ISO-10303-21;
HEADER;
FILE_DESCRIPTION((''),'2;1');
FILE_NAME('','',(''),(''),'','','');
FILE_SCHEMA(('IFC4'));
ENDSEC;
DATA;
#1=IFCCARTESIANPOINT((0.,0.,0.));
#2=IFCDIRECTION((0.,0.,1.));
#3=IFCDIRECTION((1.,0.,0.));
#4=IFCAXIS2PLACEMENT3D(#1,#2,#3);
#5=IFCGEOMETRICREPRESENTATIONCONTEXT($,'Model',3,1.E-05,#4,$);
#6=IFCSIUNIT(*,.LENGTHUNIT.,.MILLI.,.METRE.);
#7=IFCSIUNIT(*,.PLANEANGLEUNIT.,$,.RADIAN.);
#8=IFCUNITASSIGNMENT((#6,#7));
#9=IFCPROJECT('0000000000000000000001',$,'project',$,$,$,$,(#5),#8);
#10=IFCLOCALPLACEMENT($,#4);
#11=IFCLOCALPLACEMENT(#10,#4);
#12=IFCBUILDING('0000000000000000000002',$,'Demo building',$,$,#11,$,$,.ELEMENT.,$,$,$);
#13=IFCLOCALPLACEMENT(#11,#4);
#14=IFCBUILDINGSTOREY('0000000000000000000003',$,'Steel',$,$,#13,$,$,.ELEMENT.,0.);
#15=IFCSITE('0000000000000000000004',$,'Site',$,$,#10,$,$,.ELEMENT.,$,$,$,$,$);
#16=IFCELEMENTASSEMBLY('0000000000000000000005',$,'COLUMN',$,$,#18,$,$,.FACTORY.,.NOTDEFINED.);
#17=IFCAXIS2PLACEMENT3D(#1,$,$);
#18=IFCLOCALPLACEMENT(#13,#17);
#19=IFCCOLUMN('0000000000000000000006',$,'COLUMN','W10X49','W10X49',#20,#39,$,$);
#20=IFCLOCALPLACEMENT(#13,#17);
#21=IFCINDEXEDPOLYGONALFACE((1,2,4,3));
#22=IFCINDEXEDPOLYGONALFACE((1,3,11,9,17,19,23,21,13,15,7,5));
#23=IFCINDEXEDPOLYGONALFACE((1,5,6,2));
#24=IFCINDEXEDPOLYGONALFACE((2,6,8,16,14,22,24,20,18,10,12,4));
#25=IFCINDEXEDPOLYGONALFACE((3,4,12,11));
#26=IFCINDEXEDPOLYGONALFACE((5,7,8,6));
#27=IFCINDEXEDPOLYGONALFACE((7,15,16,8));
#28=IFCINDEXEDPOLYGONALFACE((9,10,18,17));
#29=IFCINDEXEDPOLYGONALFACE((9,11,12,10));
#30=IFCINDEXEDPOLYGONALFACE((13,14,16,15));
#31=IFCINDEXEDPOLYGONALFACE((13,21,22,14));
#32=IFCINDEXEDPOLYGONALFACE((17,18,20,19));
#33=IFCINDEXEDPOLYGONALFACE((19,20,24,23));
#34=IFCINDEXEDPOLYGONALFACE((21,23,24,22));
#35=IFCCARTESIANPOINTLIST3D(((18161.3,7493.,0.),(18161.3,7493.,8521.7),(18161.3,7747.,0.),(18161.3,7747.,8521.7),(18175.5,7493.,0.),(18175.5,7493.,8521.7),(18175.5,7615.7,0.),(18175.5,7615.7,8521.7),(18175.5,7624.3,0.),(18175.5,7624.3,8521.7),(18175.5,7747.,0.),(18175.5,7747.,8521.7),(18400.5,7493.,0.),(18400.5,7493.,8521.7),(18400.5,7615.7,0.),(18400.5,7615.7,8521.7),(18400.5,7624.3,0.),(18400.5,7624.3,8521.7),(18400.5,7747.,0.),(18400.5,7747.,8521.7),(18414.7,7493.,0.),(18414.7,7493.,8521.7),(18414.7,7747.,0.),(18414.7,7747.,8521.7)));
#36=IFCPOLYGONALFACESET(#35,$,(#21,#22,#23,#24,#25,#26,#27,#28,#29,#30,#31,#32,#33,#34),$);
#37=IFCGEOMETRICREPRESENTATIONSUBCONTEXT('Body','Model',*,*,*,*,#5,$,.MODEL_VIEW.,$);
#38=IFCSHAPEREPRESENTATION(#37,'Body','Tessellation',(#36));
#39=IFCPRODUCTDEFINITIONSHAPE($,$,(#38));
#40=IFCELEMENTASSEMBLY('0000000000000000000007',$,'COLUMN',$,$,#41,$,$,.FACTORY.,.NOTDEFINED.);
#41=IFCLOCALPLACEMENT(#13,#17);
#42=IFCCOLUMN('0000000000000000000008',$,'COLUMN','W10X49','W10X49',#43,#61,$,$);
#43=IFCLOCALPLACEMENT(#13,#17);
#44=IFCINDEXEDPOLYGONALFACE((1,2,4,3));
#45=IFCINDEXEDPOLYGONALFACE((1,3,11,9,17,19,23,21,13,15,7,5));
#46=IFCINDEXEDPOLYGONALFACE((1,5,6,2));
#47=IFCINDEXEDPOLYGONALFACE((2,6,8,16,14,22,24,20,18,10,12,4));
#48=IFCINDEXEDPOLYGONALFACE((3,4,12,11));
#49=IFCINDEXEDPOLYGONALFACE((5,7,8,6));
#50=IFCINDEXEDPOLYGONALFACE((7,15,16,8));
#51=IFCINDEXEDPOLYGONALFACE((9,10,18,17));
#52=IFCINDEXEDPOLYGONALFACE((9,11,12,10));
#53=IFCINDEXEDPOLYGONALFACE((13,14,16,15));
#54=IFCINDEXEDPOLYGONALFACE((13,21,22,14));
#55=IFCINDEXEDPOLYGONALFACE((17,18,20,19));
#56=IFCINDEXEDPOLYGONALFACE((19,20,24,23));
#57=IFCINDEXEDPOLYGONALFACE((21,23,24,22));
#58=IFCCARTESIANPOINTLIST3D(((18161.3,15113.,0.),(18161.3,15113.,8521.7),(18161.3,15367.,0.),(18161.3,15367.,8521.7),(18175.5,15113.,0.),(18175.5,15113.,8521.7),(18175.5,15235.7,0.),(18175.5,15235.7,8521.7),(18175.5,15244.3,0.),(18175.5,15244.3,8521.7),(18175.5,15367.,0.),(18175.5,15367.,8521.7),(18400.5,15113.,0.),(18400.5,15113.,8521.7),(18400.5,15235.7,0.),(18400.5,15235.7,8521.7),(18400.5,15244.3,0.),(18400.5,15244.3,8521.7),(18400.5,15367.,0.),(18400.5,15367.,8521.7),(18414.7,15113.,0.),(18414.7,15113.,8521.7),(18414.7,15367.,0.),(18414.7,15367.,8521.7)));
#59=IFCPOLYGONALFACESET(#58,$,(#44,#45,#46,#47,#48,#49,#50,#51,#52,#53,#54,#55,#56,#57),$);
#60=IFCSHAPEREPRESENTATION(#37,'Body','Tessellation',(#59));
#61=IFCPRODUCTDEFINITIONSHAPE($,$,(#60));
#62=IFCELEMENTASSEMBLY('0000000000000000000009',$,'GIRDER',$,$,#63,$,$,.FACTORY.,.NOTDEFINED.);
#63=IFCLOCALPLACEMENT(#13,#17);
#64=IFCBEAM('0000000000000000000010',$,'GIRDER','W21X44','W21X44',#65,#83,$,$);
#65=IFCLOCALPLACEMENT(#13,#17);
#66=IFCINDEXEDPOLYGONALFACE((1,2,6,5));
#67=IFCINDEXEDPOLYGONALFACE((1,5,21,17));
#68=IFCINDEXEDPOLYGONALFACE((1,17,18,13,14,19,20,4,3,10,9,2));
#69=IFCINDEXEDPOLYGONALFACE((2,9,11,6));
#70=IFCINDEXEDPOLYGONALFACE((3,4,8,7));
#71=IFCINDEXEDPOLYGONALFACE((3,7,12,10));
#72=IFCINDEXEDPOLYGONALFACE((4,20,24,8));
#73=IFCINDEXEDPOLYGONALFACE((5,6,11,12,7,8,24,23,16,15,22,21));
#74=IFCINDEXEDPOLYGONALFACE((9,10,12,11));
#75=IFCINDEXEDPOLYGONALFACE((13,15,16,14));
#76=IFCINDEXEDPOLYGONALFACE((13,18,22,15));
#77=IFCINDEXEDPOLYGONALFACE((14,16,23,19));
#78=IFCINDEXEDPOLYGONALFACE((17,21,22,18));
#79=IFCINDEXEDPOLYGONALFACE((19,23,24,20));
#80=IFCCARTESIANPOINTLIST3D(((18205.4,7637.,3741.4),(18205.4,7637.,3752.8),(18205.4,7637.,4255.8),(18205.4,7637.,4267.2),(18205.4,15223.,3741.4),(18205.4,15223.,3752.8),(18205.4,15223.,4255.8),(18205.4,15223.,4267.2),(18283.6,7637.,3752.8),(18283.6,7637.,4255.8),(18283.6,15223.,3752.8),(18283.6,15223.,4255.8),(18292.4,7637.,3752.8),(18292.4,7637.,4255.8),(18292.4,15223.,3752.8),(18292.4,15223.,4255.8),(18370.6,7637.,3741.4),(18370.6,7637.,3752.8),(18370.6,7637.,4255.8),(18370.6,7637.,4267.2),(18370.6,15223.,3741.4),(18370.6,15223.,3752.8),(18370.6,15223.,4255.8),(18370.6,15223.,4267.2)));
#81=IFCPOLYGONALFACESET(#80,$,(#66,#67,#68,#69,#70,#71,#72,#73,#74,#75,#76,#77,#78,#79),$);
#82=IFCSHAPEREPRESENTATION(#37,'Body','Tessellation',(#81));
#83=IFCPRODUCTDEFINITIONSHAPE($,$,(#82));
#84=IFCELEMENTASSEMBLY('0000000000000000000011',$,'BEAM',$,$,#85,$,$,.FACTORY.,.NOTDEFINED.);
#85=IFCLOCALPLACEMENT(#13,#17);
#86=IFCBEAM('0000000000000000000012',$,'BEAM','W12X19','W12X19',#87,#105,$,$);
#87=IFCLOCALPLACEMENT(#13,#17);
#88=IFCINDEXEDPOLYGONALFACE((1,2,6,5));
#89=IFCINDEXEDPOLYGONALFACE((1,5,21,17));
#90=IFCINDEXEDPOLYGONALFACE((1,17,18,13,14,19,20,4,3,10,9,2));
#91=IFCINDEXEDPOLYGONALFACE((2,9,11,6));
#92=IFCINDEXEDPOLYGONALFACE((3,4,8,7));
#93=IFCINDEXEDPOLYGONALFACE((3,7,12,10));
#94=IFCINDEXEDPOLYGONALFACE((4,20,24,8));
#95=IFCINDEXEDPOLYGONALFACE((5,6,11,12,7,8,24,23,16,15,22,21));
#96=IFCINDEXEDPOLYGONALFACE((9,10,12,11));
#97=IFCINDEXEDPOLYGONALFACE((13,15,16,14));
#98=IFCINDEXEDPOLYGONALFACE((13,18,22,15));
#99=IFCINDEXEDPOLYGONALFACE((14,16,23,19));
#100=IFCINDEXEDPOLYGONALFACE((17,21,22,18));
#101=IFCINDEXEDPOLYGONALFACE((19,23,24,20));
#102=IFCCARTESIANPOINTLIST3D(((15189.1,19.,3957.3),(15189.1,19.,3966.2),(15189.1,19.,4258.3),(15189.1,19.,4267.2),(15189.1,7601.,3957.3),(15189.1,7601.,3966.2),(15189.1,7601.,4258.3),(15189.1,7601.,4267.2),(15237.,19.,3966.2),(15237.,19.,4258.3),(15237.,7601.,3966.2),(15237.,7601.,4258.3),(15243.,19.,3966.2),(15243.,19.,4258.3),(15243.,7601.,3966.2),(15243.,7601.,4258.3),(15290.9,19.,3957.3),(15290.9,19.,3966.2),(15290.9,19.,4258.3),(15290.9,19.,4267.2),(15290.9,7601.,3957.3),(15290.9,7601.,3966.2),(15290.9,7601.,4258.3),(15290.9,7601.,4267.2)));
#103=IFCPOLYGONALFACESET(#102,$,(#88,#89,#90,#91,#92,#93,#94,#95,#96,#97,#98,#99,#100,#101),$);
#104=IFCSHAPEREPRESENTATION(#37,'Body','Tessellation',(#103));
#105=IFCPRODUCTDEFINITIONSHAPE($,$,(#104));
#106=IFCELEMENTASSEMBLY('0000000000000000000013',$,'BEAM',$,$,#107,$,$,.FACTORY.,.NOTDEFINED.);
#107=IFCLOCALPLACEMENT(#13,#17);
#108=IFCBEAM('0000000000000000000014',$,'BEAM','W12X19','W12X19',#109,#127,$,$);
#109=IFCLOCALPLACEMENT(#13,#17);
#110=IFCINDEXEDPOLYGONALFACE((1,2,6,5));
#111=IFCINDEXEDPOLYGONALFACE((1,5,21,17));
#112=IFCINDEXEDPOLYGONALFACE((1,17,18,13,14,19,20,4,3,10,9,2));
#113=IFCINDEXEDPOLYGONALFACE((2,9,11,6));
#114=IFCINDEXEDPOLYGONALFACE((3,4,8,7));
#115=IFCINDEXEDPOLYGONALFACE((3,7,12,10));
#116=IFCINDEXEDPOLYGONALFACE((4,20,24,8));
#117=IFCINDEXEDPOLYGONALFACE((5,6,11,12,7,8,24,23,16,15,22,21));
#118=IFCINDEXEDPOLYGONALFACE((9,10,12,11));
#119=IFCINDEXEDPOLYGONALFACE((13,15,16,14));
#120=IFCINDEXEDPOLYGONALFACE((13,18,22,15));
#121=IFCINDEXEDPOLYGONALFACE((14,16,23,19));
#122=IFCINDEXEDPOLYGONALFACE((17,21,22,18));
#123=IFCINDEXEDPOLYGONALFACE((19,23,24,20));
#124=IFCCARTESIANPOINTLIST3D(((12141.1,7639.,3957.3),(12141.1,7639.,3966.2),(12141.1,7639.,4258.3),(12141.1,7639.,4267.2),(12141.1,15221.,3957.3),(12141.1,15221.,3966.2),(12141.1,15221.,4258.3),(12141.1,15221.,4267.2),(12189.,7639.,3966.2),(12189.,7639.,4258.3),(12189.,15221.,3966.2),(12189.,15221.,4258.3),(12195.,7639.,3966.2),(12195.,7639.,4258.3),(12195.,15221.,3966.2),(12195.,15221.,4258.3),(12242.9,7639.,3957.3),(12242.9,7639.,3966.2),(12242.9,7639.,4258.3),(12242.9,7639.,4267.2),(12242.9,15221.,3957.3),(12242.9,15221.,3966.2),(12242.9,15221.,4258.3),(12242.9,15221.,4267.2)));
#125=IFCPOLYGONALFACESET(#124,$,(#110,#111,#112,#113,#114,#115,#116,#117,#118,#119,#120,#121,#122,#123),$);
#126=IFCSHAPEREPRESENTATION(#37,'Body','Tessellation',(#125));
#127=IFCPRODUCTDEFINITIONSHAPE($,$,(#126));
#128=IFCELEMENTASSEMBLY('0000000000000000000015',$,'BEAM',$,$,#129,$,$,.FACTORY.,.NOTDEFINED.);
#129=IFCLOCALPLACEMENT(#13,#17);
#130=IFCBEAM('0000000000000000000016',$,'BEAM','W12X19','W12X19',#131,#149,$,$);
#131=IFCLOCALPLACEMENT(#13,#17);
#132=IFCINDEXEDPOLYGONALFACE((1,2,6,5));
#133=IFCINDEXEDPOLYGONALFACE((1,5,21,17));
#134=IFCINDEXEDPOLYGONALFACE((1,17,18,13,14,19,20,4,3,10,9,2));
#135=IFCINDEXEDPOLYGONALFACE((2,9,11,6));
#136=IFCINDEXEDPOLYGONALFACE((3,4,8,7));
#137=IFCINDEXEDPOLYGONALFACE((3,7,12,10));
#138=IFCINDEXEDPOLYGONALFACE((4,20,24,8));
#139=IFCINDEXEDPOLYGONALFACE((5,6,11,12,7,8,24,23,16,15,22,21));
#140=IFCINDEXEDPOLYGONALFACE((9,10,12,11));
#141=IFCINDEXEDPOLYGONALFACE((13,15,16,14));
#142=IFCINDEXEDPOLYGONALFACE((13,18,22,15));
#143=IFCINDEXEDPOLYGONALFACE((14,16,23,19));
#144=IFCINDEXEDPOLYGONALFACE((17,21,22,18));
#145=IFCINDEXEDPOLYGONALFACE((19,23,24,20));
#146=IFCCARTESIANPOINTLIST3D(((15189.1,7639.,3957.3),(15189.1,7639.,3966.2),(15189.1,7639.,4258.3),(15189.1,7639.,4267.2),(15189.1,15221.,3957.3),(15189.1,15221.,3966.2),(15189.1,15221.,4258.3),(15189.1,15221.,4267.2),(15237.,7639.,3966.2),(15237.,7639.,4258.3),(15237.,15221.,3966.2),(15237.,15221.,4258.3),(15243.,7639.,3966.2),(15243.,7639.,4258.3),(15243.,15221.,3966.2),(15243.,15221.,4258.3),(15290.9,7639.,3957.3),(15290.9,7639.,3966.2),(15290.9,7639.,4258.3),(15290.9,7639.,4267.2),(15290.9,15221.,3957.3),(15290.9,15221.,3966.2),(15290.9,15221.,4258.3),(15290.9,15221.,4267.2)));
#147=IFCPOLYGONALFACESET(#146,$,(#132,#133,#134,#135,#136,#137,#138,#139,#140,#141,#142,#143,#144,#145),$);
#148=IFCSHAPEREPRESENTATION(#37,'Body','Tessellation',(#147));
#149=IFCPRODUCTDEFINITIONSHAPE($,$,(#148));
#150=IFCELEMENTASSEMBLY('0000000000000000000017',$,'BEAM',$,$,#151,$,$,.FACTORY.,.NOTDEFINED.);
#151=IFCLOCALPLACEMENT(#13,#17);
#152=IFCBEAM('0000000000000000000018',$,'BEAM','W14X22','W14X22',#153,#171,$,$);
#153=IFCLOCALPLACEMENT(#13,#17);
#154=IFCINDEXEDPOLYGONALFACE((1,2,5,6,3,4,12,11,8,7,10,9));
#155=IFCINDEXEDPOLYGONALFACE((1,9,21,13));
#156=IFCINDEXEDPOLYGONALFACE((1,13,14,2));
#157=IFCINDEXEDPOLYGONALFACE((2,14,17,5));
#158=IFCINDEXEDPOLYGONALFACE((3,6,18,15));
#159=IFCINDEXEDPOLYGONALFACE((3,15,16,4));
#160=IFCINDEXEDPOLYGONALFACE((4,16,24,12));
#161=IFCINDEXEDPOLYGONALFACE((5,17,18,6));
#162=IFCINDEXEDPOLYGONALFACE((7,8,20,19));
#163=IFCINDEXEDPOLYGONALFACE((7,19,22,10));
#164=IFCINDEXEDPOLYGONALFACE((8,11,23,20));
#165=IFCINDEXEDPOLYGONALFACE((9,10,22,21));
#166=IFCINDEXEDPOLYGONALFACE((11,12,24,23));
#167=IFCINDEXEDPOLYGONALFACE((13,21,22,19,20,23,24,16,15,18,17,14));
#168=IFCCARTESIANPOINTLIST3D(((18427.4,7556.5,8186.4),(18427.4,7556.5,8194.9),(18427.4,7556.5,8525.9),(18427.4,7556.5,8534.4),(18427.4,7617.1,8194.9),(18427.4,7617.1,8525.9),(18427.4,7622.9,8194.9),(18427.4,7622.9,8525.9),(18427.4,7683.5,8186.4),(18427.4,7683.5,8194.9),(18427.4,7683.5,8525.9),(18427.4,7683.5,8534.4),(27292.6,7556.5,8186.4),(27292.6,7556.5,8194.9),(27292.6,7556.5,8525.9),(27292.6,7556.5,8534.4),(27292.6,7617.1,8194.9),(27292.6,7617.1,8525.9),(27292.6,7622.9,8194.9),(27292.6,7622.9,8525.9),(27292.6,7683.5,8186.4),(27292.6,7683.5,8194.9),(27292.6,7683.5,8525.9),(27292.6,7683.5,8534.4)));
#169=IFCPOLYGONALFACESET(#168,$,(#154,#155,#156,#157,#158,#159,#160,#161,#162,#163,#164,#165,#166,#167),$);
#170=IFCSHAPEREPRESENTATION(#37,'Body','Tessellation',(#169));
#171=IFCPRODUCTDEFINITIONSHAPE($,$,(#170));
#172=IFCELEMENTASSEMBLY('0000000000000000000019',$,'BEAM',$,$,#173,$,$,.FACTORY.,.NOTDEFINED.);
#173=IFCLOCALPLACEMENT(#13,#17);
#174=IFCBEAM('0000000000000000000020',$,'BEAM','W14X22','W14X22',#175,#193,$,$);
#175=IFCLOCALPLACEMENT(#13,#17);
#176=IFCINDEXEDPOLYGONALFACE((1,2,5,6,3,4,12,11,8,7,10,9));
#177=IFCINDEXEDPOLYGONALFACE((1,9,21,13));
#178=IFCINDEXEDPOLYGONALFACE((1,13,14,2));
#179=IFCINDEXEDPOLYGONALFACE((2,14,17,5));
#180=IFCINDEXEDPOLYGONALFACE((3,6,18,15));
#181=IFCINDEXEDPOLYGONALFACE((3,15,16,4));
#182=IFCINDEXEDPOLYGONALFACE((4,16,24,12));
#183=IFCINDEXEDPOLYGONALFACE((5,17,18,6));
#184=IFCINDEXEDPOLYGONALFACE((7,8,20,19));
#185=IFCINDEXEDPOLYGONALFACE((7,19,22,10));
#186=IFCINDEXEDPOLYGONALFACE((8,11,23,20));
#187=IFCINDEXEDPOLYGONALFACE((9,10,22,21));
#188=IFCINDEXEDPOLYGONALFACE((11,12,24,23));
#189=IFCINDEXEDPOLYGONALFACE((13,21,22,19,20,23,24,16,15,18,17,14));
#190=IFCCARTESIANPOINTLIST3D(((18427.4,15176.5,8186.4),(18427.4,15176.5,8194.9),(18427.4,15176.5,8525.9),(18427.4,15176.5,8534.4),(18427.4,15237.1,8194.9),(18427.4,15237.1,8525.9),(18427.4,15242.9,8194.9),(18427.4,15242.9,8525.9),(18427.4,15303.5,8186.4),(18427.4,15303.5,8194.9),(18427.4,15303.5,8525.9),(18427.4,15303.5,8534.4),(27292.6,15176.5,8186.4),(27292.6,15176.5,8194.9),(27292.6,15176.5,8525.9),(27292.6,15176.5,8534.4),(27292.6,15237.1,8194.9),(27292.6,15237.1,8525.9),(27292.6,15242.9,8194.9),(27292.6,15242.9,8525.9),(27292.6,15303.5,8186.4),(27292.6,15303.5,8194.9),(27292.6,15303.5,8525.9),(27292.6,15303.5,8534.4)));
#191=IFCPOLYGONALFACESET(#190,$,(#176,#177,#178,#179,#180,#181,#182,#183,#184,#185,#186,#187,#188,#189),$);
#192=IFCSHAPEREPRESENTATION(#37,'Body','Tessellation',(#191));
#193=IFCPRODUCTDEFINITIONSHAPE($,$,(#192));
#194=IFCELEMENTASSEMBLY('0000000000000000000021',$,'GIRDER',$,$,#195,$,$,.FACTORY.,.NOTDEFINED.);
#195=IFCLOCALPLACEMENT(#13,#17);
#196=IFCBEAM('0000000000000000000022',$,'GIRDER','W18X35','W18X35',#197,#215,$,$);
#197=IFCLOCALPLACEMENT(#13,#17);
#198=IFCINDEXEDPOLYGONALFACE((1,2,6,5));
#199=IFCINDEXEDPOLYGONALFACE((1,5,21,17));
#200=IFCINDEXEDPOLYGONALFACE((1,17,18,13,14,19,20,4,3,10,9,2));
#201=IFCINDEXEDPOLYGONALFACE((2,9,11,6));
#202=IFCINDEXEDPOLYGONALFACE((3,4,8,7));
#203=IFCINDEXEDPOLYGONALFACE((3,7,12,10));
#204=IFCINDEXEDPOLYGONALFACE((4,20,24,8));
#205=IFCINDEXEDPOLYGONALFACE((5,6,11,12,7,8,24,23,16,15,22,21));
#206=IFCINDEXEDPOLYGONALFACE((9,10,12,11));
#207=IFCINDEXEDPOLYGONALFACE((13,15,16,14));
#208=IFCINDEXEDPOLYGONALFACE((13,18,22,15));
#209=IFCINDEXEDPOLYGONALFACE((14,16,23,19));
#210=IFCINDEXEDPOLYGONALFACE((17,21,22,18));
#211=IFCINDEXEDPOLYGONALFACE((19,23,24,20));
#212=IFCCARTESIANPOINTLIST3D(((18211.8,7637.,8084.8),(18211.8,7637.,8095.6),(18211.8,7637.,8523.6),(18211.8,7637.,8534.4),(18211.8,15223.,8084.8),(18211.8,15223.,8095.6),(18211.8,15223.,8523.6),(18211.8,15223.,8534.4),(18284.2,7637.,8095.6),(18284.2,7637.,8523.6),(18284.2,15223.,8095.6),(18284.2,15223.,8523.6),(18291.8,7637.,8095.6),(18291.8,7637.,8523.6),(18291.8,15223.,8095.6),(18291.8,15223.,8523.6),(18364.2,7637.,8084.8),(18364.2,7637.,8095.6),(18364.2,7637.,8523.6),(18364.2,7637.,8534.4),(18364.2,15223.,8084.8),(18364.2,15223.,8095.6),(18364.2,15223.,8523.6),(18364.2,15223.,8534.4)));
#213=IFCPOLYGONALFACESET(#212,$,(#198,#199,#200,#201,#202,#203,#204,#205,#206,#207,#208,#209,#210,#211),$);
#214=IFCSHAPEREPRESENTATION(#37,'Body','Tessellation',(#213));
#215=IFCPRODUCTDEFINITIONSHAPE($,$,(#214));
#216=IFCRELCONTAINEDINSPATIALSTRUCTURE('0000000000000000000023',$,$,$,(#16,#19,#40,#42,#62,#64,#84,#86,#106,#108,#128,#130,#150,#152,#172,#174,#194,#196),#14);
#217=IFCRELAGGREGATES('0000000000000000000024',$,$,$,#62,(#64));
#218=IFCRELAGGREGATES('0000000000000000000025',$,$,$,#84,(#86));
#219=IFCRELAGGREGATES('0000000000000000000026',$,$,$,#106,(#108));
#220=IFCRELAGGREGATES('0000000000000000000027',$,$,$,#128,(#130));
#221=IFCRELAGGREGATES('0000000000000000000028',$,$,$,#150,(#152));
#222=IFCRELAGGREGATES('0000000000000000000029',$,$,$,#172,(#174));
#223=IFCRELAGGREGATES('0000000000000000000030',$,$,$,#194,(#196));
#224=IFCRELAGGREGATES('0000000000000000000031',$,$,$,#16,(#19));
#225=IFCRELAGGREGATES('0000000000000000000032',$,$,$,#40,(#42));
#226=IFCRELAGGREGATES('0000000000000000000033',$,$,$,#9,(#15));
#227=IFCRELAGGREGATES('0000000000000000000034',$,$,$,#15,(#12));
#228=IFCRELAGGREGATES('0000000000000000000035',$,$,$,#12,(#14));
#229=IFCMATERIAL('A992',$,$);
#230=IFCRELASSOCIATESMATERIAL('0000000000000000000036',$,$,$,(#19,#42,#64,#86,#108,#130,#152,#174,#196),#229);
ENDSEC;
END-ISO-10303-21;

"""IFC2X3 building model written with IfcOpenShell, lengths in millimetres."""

from ifc_helpers import new_model, si_unit, frame, origin, origin_with_axes, origin_2d, place, context, subcontext, project, spatial, i_section, extrude, material, element, aggregate, save


model = new_model("IFC2X3")

# Units and contexts
model_context = context("Model", 3, precision=1e-05, world=origin_with_axes())
body_context = subcontext(model_context, "Body", "Model", "MODEL_VIEW")
ifc_project = project(units=[si_unit("LENGTHUNIT", "METRE", prefix="MILLI"), si_unit("PLANEANGLEUNIT", "RADIAN")], contexts=[model_context])

# Site, building, storey
site_placement = place(None, origin_with_axes())
site = spatial("IfcSite", under=ifc_project, at=site_placement, Name="Site", CompositionType="ELEMENT")
building_placement = place(site_placement, origin_with_axes())
building = spatial("IfcBuilding", under=site, at=building_placement, Name="Demo building", CompositionType="ELEMENT")
placement = place(building_placement, origin_with_axes())
storey = spatial("IfcBuildingStorey", under=building, at=placement, Name="Steel", CompositionType="ELEMENT", Elevation=0.0)

# Element assemblies, columns
assembly_1 = element("IfcElementAssembly", 1, at=placement, inside=storey, Name="COLUMN", AssemblyPlace="FACTORY", PredefinedType="NOTDEFINED")
ifc_material_1 = material(Name="A992")
column_1_placement = place(placement, frame((18288.0, 7620.0, 0.0), z_axis=(0.0, 0.0, 1.0), x_axis=(0.0, -1.0, 0.0)))
column_1 = element("IfcColumn", 2, at=column_1_placement, inside=storey, material=ifc_material_1, Name="COLUMN", Description="W10X49", ObjectType="W10X49", context=body_context, shape_type="SweptSolid", body=[
    extrude(i_section(OverallWidth=254.0, OverallDepth=253.5, WebThickness=8.6, FlangeThickness=14.2, at=origin_2d()), origin(), (0.0, 0.0, 1.0), 8521.7),
])
assembly_2 = element("IfcElementAssembly", 3, at=placement, inside=storey, Name="COLUMN", AssemblyPlace="FACTORY", PredefinedType="NOTDEFINED")
column_2_placement = place(placement, frame((18288.0, 15240.0, 0.0), z_axis=(0.0, 0.0, 1.0), x_axis=(0.0, -1.0, 0.0)))
column_2 = element("IfcColumn", 4, at=column_2_placement, inside=storey, material=ifc_material_1, Name="COLUMN", Description="W10X49", ObjectType="W10X49", context=body_context, shape_type="SweptSolid", body=[
    extrude(i_section(OverallWidth=254.0, OverallDepth=253.5, WebThickness=8.6, FlangeThickness=14.2, at=origin_2d()), origin(), (0.0, 0.0, 1.0), 8521.7),
])

# Element assemblies, beams
assembly_3 = element("IfcElementAssembly", 5, at=placement, inside=storey, Name="GIRDER", AssemblyPlace="FACTORY", PredefinedType="NOTDEFINED")
beam_1_placement = place(placement, frame((18288.0, 7637.0, 4004.3), z_axis=(0.0, 1.0, 0.0), x_axis=(-1.0, 0.0, 0.0)))
beam_1 = element("IfcBeam", 6, at=beam_1_placement, inside=storey, material=ifc_material_1, Name="GIRDER", Description="W21X44", ObjectType="W21X44", context=body_context, shape_type="SweptSolid", body=[
    extrude(i_section(OverallWidth=165.1, OverallDepth=525.8, WebThickness=8.9, FlangeThickness=11.4, at=origin_2d()), origin(), (0.0, 0.0, 1.0), 7586.0),
])
aggregate(assembly_3, [beam_1])
assembly_4 = element("IfcElementAssembly", 7, at=placement, inside=storey, Name="BEAM", AssemblyPlace="FACTORY", PredefinedType="NOTDEFINED")
beam_2_placement = place(placement, frame((15240.0, 19.1, 4112.3), z_axis=(0.0, 1.0, 0.0), x_axis=(-1.0, 0.0, 0.0)))
beam_2 = element("IfcBeam", 8, at=beam_2_placement, inside=storey, material=ifc_material_1, Name="BEAM", Description="W12X19", ObjectType="W12X19", context=body_context, shape_type="SweptSolid", body=[
    extrude(i_section(OverallWidth=101.9, OverallDepth=309.9, WebThickness=6.0, FlangeThickness=8.9, at=origin_2d()), origin(), (0.0, 0.0, 1.0), 7581.9),
])
aggregate(assembly_4, [beam_2])
assembly_5 = element("IfcElementAssembly", 9, at=placement, inside=storey, Name="BEAM", AssemblyPlace="FACTORY", PredefinedType="NOTDEFINED")
beam_3_placement = place(placement, frame((12192.0, 7639.1, 4112.3), z_axis=(0.0, 1.0, 0.0), x_axis=(-1.0, 0.0, 0.0)))
beam_3 = element("IfcBeam", 10, at=beam_3_placement, inside=storey, material=ifc_material_1, Name="BEAM", Description="W12X19", ObjectType="W12X19", context=body_context, shape_type="SweptSolid", body=[
    extrude(i_section(OverallWidth=101.9, OverallDepth=309.9, WebThickness=6.0, FlangeThickness=8.9, at=origin_2d()), origin(), (0.0, 0.0, 1.0), 7581.9),
])
aggregate(assembly_5, [beam_3])
assembly_6 = element("IfcElementAssembly", 11, at=placement, inside=storey, Name="BEAM", AssemblyPlace="FACTORY", PredefinedType="NOTDEFINED")
beam_4_placement = place(placement, frame((15240.0, 7639.1, 4112.3), z_axis=(0.0, 1.0, 0.0), x_axis=(-1.0, 0.0, 0.0)))
beam_4 = element("IfcBeam", 12, at=beam_4_placement, inside=storey, material=ifc_material_1, Name="BEAM", Description="W12X19", ObjectType="W12X19", context=body_context, shape_type="SweptSolid", body=[
    extrude(i_section(OverallWidth=101.9, OverallDepth=309.9, WebThickness=6.0, FlangeThickness=8.9, at=origin_2d()), origin(), (0.0, 0.0, 1.0), 7581.9),
])
aggregate(assembly_6, [beam_4])
assembly_7 = element("IfcElementAssembly", 13, at=placement, inside=storey, Name="BEAM", AssemblyPlace="FACTORY", PredefinedType="NOTDEFINED")
beam_5_placement = place(placement, frame((18427.4, 7620.0, 8360.4), z_axis=(1.0, 0.0, 0.0), x_axis=(0.0, 1.0, 0.0)))
beam_5 = element("IfcBeam", 14, at=beam_5_placement, inside=storey, material=ifc_material_1, Name="BEAM", Description="W14X22", ObjectType="W14X22", context=body_context, shape_type="SweptSolid", body=[
    extrude(i_section(OverallWidth=127.0, OverallDepth=348.0, WebThickness=5.8, FlangeThickness=8.5, at=origin_2d()), origin(), (0.0, 0.0, 1.0), 8865.1),
])
aggregate(assembly_7, [beam_5])
assembly_8 = element("IfcElementAssembly", 15, at=placement, inside=storey, Name="BEAM", AssemblyPlace="FACTORY", PredefinedType="NOTDEFINED")
beam_6_placement = place(placement, frame((18427.4, 15240.0, 8360.4), z_axis=(1.0, 0.0, 0.0), x_axis=(0.0, 1.0, 0.0)))
beam_6 = element("IfcBeam", 16, at=beam_6_placement, inside=storey, material=ifc_material_1, Name="BEAM", Description="W14X22", ObjectType="W14X22", context=body_context, shape_type="SweptSolid", body=[
    extrude(i_section(OverallWidth=127.0, OverallDepth=348.0, WebThickness=5.8, FlangeThickness=8.5, at=origin_2d()), origin(), (0.0, 0.0, 1.0), 8865.1),
])
aggregate(assembly_8, [beam_6])
assembly_9 = element("IfcElementAssembly", 17, at=placement, inside=storey, Name="GIRDER", AssemblyPlace="FACTORY", PredefinedType="NOTDEFINED")
beam_7_placement = place(placement, frame((18288.0, 7637.0, 8309.6), z_axis=(0.0, 1.0, 0.0), x_axis=(-1.0, 0.0, 0.0)))
beam_7 = element("IfcBeam", 18, at=beam_7_placement, inside=storey, material=ifc_material_1, Name="GIRDER", Description="W18X35", ObjectType="W18X35", context=body_context, shape_type="SweptSolid", body=[
    extrude(i_section(OverallWidth=152.4, OverallDepth=449.6, WebThickness=7.6, FlangeThickness=10.8, at=origin_2d()), origin(), (0.0, 0.0, 1.0), 7586.0),
])
aggregate(assembly_9, [beam_7])

aggregate(assembly_1, [column_1])
aggregate(assembly_2, [column_2])

save(model, "model.ifc")
